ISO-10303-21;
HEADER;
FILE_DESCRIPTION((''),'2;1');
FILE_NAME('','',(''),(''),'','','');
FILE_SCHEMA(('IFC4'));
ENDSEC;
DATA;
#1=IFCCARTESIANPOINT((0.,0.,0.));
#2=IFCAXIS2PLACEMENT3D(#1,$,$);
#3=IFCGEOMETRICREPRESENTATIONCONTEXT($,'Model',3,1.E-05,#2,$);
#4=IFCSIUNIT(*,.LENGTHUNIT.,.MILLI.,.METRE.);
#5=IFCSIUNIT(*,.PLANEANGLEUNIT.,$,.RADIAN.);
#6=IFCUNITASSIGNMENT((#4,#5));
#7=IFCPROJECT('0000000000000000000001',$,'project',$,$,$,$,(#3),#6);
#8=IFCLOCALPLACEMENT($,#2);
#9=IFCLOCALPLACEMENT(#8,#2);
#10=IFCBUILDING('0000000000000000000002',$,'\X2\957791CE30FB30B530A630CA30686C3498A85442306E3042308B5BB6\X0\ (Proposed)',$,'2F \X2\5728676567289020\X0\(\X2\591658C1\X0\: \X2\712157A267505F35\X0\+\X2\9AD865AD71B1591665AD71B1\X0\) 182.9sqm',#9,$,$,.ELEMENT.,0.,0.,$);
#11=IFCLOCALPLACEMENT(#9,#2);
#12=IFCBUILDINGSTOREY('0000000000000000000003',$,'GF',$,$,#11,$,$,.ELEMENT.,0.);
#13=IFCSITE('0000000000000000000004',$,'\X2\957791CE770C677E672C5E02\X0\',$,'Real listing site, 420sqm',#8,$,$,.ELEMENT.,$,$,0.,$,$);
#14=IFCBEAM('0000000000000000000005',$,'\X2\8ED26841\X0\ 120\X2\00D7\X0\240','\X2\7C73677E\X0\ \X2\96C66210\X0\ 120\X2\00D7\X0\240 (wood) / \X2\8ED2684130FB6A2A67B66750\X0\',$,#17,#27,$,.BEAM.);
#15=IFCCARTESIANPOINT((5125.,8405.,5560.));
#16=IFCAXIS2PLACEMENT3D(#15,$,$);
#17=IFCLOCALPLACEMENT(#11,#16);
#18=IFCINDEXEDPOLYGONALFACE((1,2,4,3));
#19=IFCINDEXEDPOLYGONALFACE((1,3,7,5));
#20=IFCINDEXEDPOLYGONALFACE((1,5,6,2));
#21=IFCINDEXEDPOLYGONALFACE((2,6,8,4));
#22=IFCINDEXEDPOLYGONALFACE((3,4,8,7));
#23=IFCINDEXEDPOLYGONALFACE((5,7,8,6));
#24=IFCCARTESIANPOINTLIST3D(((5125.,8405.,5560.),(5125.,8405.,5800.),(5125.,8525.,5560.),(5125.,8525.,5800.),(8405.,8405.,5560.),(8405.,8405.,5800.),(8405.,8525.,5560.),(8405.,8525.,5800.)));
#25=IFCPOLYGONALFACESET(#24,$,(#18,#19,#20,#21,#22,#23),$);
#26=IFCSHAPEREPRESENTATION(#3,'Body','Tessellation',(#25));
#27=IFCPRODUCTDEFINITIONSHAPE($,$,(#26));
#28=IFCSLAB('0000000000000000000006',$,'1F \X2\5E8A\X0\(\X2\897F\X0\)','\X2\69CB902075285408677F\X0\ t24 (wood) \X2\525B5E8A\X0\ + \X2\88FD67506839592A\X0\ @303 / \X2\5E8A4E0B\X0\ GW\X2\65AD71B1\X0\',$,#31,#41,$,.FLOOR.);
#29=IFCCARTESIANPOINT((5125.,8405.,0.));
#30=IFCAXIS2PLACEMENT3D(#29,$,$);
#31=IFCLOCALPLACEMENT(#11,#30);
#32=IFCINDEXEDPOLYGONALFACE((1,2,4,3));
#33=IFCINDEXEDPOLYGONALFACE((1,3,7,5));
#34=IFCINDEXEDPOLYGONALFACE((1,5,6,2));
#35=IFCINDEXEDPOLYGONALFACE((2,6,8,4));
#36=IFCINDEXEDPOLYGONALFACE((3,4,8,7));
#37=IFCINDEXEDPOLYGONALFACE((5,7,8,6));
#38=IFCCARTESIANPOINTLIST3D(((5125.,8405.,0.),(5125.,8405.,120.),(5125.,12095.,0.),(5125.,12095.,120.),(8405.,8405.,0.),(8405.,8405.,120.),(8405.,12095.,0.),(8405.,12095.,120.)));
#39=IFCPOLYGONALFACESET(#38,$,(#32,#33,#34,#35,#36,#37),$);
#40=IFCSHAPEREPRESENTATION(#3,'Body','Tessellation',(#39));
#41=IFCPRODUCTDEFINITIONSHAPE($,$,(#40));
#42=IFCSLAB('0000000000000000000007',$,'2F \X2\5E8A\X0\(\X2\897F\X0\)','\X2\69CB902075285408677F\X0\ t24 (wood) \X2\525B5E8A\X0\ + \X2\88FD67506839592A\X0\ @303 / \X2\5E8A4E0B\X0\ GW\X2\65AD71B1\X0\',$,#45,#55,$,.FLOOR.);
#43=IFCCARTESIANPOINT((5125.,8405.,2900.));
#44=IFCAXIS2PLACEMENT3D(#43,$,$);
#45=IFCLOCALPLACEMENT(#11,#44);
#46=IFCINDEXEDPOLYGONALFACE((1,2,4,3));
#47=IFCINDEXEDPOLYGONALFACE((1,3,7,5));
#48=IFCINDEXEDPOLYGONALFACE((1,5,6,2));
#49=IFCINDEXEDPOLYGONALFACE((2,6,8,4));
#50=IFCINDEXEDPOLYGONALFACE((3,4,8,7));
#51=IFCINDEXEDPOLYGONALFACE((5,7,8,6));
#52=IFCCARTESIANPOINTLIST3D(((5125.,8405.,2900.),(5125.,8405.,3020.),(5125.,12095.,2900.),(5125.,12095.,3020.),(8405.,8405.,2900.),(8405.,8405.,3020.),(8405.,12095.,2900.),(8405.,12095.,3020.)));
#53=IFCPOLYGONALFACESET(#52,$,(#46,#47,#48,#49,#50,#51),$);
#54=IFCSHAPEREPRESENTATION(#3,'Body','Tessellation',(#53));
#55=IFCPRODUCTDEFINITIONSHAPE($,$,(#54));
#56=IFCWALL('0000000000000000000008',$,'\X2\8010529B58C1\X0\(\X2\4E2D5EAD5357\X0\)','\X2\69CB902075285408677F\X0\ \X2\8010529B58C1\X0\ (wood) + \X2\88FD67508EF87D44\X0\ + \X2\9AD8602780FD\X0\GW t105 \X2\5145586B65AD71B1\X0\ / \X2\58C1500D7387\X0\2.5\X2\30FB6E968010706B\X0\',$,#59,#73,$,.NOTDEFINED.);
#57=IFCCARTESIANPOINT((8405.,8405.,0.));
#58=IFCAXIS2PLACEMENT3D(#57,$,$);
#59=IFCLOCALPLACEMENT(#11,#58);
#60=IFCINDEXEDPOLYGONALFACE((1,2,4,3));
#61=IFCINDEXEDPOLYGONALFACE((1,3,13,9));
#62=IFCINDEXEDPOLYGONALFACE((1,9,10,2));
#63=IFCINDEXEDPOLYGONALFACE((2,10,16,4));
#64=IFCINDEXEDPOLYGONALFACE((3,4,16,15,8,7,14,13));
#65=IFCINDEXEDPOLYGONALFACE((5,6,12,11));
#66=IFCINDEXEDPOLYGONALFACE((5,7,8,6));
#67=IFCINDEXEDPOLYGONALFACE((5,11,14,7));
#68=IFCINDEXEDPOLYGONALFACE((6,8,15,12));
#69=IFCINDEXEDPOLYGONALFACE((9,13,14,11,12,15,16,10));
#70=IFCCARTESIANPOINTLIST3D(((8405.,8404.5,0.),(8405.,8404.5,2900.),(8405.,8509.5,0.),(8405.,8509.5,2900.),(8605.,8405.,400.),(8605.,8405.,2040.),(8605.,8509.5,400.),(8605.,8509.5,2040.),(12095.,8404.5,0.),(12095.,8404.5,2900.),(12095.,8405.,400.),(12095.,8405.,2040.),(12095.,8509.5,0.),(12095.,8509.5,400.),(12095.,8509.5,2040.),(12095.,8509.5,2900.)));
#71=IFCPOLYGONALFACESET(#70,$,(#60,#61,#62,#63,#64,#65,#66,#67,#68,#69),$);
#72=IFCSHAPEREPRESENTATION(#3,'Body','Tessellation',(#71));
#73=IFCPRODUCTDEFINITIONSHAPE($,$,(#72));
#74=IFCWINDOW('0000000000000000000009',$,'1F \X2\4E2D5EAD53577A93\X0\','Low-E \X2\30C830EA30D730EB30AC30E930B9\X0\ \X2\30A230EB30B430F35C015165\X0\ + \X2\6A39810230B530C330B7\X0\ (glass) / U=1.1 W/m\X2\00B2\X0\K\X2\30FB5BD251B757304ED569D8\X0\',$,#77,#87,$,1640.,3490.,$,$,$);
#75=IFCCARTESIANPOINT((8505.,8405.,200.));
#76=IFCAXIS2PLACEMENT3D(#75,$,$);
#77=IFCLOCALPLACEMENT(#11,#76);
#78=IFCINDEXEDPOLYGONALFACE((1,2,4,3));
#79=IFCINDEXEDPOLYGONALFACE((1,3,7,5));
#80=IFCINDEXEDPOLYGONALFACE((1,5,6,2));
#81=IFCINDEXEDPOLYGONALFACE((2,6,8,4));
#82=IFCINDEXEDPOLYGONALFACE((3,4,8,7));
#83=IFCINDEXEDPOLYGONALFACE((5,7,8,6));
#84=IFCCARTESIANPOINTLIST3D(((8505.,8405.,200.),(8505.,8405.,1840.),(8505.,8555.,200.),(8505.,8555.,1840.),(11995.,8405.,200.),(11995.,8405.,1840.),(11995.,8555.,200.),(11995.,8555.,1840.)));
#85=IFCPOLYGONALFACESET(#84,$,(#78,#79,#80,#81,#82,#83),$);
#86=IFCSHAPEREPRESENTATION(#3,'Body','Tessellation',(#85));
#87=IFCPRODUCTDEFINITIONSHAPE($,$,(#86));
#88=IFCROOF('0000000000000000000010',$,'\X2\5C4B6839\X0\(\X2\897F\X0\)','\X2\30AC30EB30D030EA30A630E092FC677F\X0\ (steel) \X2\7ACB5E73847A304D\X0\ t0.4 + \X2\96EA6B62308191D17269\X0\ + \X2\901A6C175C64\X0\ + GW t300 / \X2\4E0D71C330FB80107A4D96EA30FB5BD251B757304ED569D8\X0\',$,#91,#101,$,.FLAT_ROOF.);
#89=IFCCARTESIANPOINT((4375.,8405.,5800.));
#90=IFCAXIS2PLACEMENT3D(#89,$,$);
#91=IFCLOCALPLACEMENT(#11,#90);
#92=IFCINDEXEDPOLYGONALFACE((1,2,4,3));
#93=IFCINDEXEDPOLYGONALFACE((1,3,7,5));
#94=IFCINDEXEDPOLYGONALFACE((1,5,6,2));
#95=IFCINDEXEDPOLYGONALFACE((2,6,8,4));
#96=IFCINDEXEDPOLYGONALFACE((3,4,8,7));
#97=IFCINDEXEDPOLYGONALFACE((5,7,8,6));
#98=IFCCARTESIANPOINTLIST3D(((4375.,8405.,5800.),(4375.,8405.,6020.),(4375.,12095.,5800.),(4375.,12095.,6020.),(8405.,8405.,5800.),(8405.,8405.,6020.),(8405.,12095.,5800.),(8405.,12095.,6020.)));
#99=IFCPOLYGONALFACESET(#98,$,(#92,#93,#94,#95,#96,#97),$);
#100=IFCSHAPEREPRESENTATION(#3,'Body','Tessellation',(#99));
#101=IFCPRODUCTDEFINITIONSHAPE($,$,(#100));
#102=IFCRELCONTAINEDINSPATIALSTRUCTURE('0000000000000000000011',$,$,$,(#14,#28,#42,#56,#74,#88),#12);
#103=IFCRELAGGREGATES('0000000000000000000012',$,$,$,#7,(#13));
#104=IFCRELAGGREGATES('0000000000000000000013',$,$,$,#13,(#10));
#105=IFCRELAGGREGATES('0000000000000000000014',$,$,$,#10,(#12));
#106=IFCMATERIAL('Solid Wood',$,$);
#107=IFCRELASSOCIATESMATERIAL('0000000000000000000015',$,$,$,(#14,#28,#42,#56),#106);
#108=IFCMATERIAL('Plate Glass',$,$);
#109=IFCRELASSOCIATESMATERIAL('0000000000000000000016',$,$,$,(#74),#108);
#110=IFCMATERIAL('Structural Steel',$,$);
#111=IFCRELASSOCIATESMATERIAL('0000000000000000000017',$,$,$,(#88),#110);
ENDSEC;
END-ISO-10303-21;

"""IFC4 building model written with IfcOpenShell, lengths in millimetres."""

from ifc_helpers import new_model, si_unit, frame, frame_2d, origin, place, context, project, spatial, rectangle, extrude, material, element, fill, save


model = new_model("IFC4")

# Units and contexts
model_context = context("Model", 3, precision=1e-05, world=origin())
ifc_project = project(units=[si_unit("LENGTHUNIT", "METRE", prefix="MILLI"), si_unit("PLANEANGLEUNIT", "RADIAN")], contexts=[model_context])

# Site, building, storey
site_placement = place(None, origin())
site = spatial("IfcSite", under=ifc_project, at=site_placement, Name="長野県松本市", ObjectType="Real listing site, 420sqm", CompositionType="ELEMENT", RefElevation=0.0)
building_placement = place(site_placement, origin())
building = spatial("IfcBuilding", under=site, at=building_placement, Name="長野・サウナと水風呂のある家 (Proposed)", ObjectType="2F 在来木造(外壁: 無垢材張+高断熱外断熱) 182.9sqm", CompositionType="ELEMENT", ElevationOfRefHeight=0.0, ElevationOfTerrain=0.0)
storey_placement = place(building_placement, origin())
storey = spatial("IfcBuildingStorey", under=building, at=storey_placement, Name="GF", CompositionType="ELEMENT", Elevation=0.0)

# Shared definitions
ifc_material_1 = material(Name="Solid Wood")

# Beam
beam_1_placement = place(storey_placement, frame((5125.0, 8405.0, 5560.0)))
element("IfcBeam", 1, at=beam_1_placement, inside=storey, material=ifc_material_1, Name="軒桁 120×240", Description="米松 集成 120×240 (wood) / 軒桁・横架材", PredefinedType="BEAM", context=model_context, shape_type="SweptSolid", body=[
    extrude(rectangle(XDim=3280.0, YDim=120.0, at=frame_2d((1640.0, 60.0))), frame((5125.0, 8405.0, 5560.0)), (0.0, 0.0, 1.0), 240.0),
])

# Slabs
slab_1_placement = place(storey_placement, frame((5125.0, 8405.0, 0.0)))
element("IfcSlab", 2, at=slab_1_placement, inside=storey, material=ifc_material_1, Name="1F 床(西)", Description="構造用合板 t24 (wood) 剛床 + 製材根太 @303 / 床下 GW断熱", PredefinedType="FLOOR", context=model_context, shape_type="SweptSolid", body=[
    extrude(rectangle(XDim=3280.0, YDim=3690.0, at=frame_2d((1640.0, 1845.0))), frame((5125.0, 8405.0, 0.0)), (0.0, 0.0, 1.0), 120.0),
])
slab_2_placement = place(storey_placement, frame((5125.0, 8405.0, 2900.0)))
element("IfcSlab", 3, at=slab_2_placement, inside=storey, material=ifc_material_1, Name="2F 床(西)", Description="構造用合板 t24 (wood) 剛床 + 製材根太 @303 / 床下 GW断熱", PredefinedType="FLOOR", context=model_context, shape_type="SweptSolid", body=[
    extrude(rectangle(XDim=3280.0, YDim=3690.0, at=frame_2d((1640.0, 1845.0))), frame((5125.0, 8405.0, 2900.0)), (0.0, 0.0, 1.0), 120.0),
])

# Wall, opening, window
wall_placement = place(storey_placement, frame((8405.0, 8405.0, 0.0)))
wall = element("IfcWall", 4, at=wall_placement, inside=storey, material=ifc_material_1, Name="耐力壁(中庭南)", Description="構造用合板 耐力壁 (wood) + 製材軸組 + 高性能GW t105 充填断熱 / 壁倍率2.5・準耐火", PredefinedType="NOTDEFINED", context=model_context, shape_type="SweptSolid", body=[
    extrude(rectangle(XDim=3690.0, YDim=105.0, at=frame_2d((1845.0, 52.0))), frame((8405.0, 8405.0, 0.0)), (0.0, 0.0, 1.0), 2900.0),
])
opening_placement = place(storey_placement, frame((8505.0, 8405.0, 200.0)))
opening = element("IfcOpeningElement", 5, at=opening_placement, cuts=wall, PredefinedType="NOTDEFINED", context=model_context, shape_type="SweptSolid", body=[
    extrude(rectangle(XDim=3490.0, YDim=150.0, at=frame_2d((1745.0, 75.0))), frame((8505.0, 8405.0, 200.0)), (0.0, 0.0, 1.0), 1640.0),
])
ifc_material_2 = material(Name="Plate Glass")
window_placement = place(storey_placement, frame((8505.0, 8405.0, 200.0)))
window = element("IfcWindow", 6, at=window_placement, inside=storey, material=ifc_material_2, Name="1F 中庭南窓", Description="Low-E トリプルガラス アルゴン封入 + 樹脂サッシ (glass) / U=1.1 W/m²K・寒冷地仕様", OverallHeight=1640.0, OverallWidth=3490.0, context=model_context, shape_type="SweptSolid", body=[
    extrude(rectangle(XDim=3490.0, YDim=150.0, at=frame_2d((1745.0, 75.0))), frame((8505.0, 8405.0, 200.0)), (0.0, 0.0, 1.0), 1640.0),
])
fill(opening, window)

# Roof
ifc_material_3 = material(Name="Structural Steel")
for number, where, name in (
    (7, (4375.0, 8405.0, 5800.0), "屋根(西)"),
):
    element("IfcRoof", number, at=place(storey_placement, frame(where)), inside=storey, material=ifc_material_3, Name=name, Description="ガルバリウム鋼板 (steel) 立平葺き t0.4 + 雪止め金物 + 通気層 + GW t300 / 不燃・耐積雪・寒冷地仕様", PredefinedType="FLAT_ROOF", context=model_context, shape_type="SweptSolid", body=[
        extrude(rectangle(XDim=4030.0, YDim=3690.0, at=frame_2d((2015.0, 1845.0))), frame((4375.0, 8405.0, 5800.0)), (0.0, 0.0, 1.0), 220.0),
    ])

save(model, "model.ifc")
